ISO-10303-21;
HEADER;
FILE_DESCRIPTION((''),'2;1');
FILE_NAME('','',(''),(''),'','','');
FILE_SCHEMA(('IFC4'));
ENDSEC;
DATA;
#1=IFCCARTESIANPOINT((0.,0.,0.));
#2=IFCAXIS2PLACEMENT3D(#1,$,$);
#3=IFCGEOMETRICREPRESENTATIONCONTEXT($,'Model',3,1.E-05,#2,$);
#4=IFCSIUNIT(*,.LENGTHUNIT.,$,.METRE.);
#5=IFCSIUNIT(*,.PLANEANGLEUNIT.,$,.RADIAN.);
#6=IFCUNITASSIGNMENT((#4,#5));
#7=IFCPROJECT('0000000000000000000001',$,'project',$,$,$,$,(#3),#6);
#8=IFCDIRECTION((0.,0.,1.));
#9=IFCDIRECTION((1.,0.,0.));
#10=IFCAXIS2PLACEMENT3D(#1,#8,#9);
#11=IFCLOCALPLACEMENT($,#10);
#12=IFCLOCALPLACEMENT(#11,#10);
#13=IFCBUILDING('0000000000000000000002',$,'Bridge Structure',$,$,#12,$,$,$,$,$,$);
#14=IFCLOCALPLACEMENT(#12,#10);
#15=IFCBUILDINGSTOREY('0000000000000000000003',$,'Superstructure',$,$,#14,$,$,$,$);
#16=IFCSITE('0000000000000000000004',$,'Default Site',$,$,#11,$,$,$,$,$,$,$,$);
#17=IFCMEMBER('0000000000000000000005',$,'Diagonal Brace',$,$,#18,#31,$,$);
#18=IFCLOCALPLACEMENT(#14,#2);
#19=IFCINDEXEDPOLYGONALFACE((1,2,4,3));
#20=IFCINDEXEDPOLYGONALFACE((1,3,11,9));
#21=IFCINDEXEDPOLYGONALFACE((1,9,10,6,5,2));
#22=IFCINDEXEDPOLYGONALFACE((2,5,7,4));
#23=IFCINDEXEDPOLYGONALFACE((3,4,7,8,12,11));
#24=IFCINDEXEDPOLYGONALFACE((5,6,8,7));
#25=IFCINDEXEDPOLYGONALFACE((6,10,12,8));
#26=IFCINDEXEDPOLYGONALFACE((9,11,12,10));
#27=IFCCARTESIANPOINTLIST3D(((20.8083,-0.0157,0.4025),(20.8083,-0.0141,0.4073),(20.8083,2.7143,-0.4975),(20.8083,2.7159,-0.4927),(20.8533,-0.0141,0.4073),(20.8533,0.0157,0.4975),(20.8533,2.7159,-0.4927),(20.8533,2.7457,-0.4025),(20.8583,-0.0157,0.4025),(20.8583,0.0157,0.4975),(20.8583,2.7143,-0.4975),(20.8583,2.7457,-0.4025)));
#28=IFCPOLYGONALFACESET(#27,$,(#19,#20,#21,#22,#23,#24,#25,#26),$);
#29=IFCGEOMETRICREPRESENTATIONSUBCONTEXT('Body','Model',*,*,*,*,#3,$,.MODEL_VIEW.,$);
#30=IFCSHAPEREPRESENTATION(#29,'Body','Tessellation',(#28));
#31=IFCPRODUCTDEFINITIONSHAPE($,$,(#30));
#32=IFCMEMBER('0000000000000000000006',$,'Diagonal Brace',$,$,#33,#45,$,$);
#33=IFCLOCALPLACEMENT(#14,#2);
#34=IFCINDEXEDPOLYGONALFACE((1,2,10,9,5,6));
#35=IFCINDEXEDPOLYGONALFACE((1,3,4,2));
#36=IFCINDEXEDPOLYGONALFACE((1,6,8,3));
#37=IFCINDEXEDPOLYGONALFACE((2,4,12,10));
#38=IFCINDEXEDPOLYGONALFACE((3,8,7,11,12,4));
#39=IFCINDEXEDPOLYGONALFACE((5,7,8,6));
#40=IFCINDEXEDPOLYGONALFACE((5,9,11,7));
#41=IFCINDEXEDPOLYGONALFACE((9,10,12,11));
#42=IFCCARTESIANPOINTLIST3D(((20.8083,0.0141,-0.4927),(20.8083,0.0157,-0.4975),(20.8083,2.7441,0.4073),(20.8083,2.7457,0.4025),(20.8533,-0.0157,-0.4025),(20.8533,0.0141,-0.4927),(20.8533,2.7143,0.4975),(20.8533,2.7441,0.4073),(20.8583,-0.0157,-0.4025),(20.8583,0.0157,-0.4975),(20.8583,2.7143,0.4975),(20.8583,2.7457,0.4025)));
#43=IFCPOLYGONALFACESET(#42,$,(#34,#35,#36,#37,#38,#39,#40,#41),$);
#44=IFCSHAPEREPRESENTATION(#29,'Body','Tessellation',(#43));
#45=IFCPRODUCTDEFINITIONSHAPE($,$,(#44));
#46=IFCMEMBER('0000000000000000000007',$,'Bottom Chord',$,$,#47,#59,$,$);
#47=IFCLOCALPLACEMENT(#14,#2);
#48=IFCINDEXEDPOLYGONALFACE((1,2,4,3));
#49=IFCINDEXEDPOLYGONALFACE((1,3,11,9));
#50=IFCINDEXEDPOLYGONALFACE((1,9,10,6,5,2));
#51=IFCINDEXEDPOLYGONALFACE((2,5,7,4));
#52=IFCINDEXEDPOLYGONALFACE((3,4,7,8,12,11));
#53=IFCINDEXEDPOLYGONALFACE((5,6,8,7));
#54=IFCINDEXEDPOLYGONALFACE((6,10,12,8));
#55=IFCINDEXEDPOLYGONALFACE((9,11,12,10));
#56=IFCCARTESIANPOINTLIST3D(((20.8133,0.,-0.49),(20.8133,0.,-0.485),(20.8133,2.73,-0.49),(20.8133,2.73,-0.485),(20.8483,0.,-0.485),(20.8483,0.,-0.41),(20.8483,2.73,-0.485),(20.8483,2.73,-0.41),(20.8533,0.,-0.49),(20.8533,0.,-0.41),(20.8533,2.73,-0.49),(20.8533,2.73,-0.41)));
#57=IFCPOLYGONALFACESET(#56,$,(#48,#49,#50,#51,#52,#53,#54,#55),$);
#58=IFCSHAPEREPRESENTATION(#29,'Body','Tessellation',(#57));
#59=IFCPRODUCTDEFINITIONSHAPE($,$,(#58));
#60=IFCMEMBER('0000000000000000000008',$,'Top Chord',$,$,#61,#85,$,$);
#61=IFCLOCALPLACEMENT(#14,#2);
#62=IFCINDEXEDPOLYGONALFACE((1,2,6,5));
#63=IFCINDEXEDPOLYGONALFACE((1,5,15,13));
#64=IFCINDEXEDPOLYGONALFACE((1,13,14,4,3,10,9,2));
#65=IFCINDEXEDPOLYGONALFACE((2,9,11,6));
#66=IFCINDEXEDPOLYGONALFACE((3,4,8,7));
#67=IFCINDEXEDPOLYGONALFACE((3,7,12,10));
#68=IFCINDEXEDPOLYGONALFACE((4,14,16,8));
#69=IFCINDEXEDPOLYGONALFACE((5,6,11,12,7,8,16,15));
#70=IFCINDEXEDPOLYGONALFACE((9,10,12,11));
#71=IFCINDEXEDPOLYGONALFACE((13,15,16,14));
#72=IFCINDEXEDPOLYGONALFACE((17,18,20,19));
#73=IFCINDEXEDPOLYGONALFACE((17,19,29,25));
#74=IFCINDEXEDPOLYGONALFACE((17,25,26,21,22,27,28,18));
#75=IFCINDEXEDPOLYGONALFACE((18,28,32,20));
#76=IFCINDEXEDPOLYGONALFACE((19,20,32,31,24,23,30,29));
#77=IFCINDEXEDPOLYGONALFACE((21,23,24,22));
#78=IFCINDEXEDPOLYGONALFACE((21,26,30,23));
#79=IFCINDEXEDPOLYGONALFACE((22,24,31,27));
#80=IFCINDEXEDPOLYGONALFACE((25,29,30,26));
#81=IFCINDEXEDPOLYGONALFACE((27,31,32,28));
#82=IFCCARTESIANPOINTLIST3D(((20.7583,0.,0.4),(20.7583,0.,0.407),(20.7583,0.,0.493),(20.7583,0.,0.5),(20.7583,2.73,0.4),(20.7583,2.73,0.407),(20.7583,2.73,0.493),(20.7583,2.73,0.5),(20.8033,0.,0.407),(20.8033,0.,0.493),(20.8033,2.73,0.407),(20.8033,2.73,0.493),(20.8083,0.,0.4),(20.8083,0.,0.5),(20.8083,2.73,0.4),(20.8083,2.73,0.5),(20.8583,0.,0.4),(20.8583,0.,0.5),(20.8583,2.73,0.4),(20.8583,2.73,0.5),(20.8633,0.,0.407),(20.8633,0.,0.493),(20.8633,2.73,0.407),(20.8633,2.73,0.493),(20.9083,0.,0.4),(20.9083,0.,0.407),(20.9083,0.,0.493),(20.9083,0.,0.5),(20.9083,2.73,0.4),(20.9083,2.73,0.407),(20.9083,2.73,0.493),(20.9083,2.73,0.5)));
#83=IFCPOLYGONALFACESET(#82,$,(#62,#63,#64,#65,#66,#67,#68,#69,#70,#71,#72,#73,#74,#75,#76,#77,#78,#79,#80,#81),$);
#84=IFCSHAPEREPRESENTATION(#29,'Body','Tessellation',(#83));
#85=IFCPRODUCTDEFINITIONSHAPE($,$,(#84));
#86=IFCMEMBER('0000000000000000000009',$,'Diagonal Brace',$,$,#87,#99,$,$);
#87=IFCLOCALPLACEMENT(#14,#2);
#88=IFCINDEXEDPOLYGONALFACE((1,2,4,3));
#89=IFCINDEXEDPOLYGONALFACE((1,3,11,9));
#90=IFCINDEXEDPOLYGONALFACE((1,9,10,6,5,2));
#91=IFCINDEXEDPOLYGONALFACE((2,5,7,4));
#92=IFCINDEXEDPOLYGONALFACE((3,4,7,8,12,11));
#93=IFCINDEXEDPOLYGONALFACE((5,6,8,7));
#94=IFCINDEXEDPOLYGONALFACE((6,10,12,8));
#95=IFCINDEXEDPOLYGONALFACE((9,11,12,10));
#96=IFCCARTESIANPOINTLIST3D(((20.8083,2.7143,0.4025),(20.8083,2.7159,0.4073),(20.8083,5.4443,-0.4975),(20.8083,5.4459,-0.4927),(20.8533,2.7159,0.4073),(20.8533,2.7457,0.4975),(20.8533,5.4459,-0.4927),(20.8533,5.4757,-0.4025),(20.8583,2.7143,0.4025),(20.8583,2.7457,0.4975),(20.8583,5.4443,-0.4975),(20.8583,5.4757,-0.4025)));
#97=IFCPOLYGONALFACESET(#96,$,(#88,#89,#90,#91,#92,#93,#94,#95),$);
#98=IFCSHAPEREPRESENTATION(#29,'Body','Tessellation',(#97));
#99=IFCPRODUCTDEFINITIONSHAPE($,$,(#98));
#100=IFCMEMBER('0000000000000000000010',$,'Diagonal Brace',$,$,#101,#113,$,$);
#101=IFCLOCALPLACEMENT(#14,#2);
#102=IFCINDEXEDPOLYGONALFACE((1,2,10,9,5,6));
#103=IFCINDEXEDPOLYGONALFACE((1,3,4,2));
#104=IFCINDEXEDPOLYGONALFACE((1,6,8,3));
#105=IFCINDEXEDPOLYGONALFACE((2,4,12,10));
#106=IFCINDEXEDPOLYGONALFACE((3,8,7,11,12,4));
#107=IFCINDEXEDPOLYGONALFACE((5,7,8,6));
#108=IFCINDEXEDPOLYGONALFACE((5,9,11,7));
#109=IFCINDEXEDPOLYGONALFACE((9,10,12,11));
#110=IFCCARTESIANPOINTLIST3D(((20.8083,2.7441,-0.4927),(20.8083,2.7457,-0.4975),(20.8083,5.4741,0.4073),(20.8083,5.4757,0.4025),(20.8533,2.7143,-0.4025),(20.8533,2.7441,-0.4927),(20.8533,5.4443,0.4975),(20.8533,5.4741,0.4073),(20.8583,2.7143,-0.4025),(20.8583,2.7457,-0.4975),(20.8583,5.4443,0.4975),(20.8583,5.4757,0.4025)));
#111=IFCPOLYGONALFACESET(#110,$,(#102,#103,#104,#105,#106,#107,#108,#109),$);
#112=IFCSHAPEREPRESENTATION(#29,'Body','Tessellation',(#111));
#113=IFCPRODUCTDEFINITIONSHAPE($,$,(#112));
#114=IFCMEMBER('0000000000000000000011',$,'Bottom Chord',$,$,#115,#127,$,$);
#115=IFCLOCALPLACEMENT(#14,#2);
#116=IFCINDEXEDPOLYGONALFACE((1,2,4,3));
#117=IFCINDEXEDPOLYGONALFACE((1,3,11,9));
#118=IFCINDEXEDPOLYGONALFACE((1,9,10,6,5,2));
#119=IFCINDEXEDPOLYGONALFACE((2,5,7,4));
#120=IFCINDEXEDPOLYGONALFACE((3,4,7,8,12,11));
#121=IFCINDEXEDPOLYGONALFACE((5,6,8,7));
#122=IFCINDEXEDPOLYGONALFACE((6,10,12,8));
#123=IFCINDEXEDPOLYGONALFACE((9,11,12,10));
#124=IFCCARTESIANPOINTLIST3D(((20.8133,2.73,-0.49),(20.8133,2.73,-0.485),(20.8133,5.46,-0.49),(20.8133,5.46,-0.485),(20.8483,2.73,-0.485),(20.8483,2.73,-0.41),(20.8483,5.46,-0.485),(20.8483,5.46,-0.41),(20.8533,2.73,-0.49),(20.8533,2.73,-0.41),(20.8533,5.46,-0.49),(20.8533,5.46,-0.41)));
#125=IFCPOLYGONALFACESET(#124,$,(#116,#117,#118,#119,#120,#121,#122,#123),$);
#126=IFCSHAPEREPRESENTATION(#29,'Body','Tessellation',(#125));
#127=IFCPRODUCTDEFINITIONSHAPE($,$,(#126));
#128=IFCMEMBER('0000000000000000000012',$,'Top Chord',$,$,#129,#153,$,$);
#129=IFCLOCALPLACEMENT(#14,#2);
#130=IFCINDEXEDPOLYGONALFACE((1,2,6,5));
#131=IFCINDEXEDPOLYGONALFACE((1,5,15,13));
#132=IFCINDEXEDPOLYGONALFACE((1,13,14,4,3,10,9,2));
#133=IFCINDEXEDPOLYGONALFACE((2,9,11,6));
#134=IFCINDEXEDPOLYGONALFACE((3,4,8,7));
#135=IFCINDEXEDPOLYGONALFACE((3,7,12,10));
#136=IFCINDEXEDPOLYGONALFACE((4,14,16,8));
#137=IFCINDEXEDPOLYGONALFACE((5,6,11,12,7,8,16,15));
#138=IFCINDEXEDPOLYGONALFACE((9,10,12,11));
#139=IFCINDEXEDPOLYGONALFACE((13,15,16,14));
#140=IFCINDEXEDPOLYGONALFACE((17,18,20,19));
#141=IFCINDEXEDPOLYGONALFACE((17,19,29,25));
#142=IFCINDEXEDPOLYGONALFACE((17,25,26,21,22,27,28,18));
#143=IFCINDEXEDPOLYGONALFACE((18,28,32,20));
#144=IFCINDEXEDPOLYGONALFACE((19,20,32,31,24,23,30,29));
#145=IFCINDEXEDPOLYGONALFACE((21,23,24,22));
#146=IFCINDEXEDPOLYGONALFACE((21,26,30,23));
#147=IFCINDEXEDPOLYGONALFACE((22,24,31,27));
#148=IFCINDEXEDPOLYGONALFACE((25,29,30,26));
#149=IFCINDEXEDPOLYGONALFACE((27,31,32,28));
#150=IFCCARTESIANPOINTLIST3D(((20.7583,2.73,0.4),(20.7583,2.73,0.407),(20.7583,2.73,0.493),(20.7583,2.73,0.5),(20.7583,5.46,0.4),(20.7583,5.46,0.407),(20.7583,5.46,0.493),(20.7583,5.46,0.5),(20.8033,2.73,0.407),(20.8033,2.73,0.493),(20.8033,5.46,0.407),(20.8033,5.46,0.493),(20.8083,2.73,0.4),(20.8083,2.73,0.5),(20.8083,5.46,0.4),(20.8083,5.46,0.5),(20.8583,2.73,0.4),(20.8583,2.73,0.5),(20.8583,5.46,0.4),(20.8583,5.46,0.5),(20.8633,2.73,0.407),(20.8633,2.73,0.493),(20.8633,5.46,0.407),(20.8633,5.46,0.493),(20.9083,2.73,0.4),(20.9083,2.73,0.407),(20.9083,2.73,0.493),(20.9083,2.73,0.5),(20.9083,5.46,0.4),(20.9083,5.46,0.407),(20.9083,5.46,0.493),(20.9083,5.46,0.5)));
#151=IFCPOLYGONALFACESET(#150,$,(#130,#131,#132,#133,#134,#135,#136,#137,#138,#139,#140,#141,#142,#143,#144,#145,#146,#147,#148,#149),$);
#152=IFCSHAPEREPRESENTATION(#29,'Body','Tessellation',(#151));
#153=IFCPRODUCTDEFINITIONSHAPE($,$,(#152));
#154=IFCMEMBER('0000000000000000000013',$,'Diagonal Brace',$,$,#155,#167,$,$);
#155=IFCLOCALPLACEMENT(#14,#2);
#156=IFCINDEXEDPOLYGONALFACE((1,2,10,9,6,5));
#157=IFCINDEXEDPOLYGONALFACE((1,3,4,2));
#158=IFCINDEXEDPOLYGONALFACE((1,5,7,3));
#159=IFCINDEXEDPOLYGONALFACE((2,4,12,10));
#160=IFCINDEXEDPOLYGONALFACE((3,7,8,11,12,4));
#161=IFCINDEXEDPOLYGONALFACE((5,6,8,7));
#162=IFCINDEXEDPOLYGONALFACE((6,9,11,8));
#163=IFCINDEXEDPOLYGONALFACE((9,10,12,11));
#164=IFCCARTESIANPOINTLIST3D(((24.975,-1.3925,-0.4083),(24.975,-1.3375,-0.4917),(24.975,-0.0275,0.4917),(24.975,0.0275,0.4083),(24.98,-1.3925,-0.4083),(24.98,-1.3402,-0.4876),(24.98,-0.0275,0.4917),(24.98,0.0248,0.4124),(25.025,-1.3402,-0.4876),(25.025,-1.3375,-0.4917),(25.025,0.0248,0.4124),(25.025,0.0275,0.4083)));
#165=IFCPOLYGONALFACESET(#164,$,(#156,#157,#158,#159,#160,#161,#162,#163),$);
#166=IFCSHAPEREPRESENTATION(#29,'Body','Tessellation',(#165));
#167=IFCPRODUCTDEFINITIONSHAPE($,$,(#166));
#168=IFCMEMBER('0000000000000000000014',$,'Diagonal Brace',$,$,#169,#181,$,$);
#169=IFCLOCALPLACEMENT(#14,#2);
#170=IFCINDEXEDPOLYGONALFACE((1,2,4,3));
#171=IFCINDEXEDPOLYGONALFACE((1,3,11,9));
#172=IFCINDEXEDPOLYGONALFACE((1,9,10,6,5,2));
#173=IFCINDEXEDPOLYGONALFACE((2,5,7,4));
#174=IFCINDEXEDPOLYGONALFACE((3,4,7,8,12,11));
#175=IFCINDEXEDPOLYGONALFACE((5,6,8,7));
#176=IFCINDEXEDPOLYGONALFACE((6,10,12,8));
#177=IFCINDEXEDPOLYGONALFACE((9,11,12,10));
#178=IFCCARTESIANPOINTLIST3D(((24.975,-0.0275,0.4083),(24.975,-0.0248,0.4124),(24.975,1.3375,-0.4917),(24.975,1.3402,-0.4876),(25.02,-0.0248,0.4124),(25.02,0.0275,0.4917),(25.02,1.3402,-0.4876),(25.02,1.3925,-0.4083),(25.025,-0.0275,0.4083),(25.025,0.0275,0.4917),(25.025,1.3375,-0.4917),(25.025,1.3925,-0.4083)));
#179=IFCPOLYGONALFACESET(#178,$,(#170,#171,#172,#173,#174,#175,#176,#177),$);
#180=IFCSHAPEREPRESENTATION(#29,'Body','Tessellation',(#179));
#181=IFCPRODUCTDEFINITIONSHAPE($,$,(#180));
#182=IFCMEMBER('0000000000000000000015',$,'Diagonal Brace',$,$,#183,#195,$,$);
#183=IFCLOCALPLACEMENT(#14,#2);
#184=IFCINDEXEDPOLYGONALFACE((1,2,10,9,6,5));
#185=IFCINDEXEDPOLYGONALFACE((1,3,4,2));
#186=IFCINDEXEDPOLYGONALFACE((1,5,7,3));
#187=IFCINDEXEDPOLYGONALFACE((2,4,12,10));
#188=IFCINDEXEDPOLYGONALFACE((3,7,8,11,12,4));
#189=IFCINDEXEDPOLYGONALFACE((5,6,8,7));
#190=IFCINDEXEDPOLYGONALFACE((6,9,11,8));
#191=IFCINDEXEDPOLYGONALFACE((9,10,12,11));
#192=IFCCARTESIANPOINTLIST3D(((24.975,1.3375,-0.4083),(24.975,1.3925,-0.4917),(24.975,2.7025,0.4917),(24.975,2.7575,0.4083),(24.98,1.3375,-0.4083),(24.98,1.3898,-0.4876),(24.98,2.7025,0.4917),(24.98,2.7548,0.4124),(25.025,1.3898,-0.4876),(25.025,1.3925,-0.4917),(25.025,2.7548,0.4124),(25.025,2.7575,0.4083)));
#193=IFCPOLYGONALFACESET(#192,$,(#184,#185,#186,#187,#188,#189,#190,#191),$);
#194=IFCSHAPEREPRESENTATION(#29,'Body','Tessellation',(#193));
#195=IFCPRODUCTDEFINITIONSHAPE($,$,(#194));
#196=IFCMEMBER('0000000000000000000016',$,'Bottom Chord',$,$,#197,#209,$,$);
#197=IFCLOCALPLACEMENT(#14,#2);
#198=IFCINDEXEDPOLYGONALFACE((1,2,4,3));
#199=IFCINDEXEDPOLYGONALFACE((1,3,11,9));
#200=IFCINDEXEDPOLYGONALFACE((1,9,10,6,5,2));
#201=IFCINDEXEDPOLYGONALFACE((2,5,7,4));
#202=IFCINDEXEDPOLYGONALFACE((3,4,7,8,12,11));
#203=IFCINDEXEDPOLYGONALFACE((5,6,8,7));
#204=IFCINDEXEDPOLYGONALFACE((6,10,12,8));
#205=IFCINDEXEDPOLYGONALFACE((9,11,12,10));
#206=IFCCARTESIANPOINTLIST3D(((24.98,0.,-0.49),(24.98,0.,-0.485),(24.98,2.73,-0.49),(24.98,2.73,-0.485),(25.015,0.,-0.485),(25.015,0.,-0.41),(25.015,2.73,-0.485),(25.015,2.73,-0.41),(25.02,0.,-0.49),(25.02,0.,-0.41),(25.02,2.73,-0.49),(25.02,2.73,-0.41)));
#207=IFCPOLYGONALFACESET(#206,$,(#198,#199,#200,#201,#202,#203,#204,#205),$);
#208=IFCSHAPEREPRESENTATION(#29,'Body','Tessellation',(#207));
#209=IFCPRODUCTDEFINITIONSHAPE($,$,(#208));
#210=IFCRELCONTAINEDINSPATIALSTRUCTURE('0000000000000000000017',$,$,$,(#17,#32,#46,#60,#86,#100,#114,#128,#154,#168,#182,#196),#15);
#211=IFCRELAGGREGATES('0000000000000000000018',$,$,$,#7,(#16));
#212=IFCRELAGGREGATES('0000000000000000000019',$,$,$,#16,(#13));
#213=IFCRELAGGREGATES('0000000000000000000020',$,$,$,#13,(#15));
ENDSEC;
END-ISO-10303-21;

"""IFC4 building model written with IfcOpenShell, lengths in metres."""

from ifc_helpers import new_model, si_unit, frame, origin, origin_with_axes, origin_2d_with_axis, place, context, subcontext, project, spatial, polyline, l_section, outline, composite_profile, extrude, element, save


model = new_model("IFC4")

# Units and contexts
model_context = context("Model", 3, precision=1e-05, world=origin())
body_context = subcontext(model_context, "Body", "Model", "MODEL_VIEW")
ifc_project = project(units=[si_unit("LENGTHUNIT", "METRE"), si_unit("PLANEANGLEUNIT", "RADIAN")], contexts=[model_context])

# Site, building, storey
site_placement = place(None, origin_with_axes())
site = spatial("IfcSite", under=ifc_project, at=site_placement, Name="Default Site")
building_placement = place(site_placement, origin_with_axes())
building = spatial("IfcBuilding", under=site, at=building_placement, Name="Bridge Structure")
storey_placement = place(building_placement, origin_with_axes())
storey = spatial("IfcBuildingStorey", under=building, at=storey_placement, Name="Superstructure")

# Members
for number, where, z_axis, x_axis, name in (
    (1, (20.8333, 0.0, 0.45), (0.0, 0.949722, -0.313095), (-1.0, 0.0, 0.0), "Diagonal Brace"),
    (2, (20.8333, 0.0, -0.45), (0.0, 0.949722, 0.313095), (-1.0, 0.0, 0.0), "Diagonal Brace"),
):
    element("IfcMember", number, at=place(storey_placement, frame(where, z_axis=z_axis, x_axis=x_axis)), inside=storey, Name=name, context=body_context, shape_type="SweptSolid", body=[
        extrude(l_section(Depth=0.1, Width=0.05, Thickness=0.005, at=origin_2d_with_axis()), origin_with_axes(), (0.0, 0.0, 1.0), 2.8745),
    ])
member_1_placement = place(storey_placement, frame((20.8333, 0.0, -0.45), z_axis=(0.0, 1.0, 0.0), x_axis=(-1.0, 0.0, 0.0)))
element("IfcMember", 3, at=member_1_placement, inside=storey, Name="Bottom Chord", context=body_context, shape_type="SweptSolid", body=[
    extrude(l_section(Depth=0.08, Width=0.04, Thickness=0.005, at=origin_2d_with_axis()), origin_with_axes(), (0.0, 0.0, 1.0), 2.73),
])
member_2_placement = place(storey_placement, frame((20.8333, 0.0, 0.45), z_axis=(0.0, 1.0, 0.0), x_axis=(-1.0, 0.0, 0.0)))
element("IfcMember", 4, at=member_2_placement, inside=storey, Name="Top Chord", context=body_context, shape_type="SweptSolid", body=[
    extrude(composite_profile([outline(polyline([(-0.025, -0.05), (-0.025, 0.05), (-0.075, 0.05), (-0.075, 0.043), (-0.03, 0.043), (-0.03, -0.043), (-0.075, -0.043), (-0.075, -0.05), (-0.025, -0.05)])), outline(polyline([(0.025, -0.05), (0.075, -0.05), (0.075, -0.043), (0.03, -0.043), (0.03, 0.043), (0.075, 0.043), (0.075, 0.05), (0.025, 0.05), (0.025, -0.05)]))]), origin_with_axes(), (0.0, 0.0, 1.0), 2.73),
])
for number, where, z_axis, x_axis, name in (
    (5, (20.8333, 2.73, 0.45), (0.0, 0.949722, -0.313095), (-1.0, 0.0, 0.0), "Diagonal Brace"),
    (6, (20.8333, 2.73, -0.45), (0.0, 0.949722, 0.313095), (-1.0, 0.0, 0.0), "Diagonal Brace"),
):
    element("IfcMember", number, at=place(storey_placement, frame(where, z_axis=z_axis, x_axis=x_axis)), inside=storey, Name=name, context=body_context, shape_type="SweptSolid", body=[
        extrude(l_section(Depth=0.1, Width=0.05, Thickness=0.005, at=origin_2d_with_axis()), origin_with_axes(), (0.0, 0.0, 1.0), 2.8745),
    ])
member_3_placement = place(storey_placement, frame((20.8333, 2.73, -0.45), z_axis=(0.0, 1.0, 0.0), x_axis=(-1.0, 0.0, 0.0)))
element("IfcMember", 7, at=member_3_placement, inside=storey, Name="Bottom Chord", context=body_context, shape_type="SweptSolid", body=[
    extrude(l_section(Depth=0.08, Width=0.04, Thickness=0.005, at=origin_2d_with_axis()), origin_with_axes(), (0.0, 0.0, 1.0), 2.73),
])
member_4_placement = place(storey_placement, frame((20.8333, 2.73, 0.45), z_axis=(0.0, 1.0, 0.0), x_axis=(-1.0, 0.0, 0.0)))
element("IfcMember", 8, at=member_4_placement, inside=storey, Name="Top Chord", context=body_context, shape_type="SweptSolid", body=[
    extrude(composite_profile([outline(polyline([(-0.025, -0.05), (-0.025, 0.05), (-0.075, 0.05), (-0.075, 0.043), (-0.03, 0.043), (-0.03, -0.043), (-0.075, -0.043), (-0.075, -0.05), (-0.025, -0.05)])), outline(polyline([(0.025, -0.05), (0.075, -0.05), (0.075, -0.043), (0.03, -0.043), (0.03, 0.043), (0.075, 0.043), (0.075, 0.05), (0.025, 0.05), (0.025, -0.05)]))]), origin_with_axes(), (0.0, 0.0, 1.0), 2.73),
])
for number, where, z_axis, x_axis, name in (
    (9, (25.0, 0.0, 0.45), (0.0, -0.834862, -0.550459), (1.0, 0.0, 0.0), "Diagonal Brace"),
    (10, (25.0, 0.0, 0.45), (0.0, 0.834862, -0.550459), (-1.0, 0.0, 0.0), "Diagonal Brace"),
    (11, (25.0, 2.73, 0.45), (0.0, -0.834862, -0.550459), (1.0, 0.0, 0.0), "Diagonal Brace"),
):
    element("IfcMember", number, at=place(storey_placement, frame(where, z_axis=z_axis, x_axis=x_axis)), inside=storey, Name=name, context=body_context, shape_type="SweptSolid", body=[
        extrude(l_section(Depth=0.1, Width=0.05, Thickness=0.005, at=origin_2d_with_axis()), origin_with_axes(), (0.0, 0.0, 1.0), 1.635),
    ])
member_5_placement = place(storey_placement, frame((25.0, 0.0, -0.45), z_axis=(0.0, 1.0, 0.0), x_axis=(-1.0, 0.0, 0.0)))
element("IfcMember", 12, at=member_5_placement, inside=storey, Name="Bottom Chord", context=body_context, shape_type="SweptSolid", body=[
    extrude(l_section(Depth=0.08, Width=0.04, Thickness=0.005, at=origin_2d_with_axis()), origin_with_axes(), (0.0, 0.0, 1.0), 2.73),
])

save(model, "model.ifc")
